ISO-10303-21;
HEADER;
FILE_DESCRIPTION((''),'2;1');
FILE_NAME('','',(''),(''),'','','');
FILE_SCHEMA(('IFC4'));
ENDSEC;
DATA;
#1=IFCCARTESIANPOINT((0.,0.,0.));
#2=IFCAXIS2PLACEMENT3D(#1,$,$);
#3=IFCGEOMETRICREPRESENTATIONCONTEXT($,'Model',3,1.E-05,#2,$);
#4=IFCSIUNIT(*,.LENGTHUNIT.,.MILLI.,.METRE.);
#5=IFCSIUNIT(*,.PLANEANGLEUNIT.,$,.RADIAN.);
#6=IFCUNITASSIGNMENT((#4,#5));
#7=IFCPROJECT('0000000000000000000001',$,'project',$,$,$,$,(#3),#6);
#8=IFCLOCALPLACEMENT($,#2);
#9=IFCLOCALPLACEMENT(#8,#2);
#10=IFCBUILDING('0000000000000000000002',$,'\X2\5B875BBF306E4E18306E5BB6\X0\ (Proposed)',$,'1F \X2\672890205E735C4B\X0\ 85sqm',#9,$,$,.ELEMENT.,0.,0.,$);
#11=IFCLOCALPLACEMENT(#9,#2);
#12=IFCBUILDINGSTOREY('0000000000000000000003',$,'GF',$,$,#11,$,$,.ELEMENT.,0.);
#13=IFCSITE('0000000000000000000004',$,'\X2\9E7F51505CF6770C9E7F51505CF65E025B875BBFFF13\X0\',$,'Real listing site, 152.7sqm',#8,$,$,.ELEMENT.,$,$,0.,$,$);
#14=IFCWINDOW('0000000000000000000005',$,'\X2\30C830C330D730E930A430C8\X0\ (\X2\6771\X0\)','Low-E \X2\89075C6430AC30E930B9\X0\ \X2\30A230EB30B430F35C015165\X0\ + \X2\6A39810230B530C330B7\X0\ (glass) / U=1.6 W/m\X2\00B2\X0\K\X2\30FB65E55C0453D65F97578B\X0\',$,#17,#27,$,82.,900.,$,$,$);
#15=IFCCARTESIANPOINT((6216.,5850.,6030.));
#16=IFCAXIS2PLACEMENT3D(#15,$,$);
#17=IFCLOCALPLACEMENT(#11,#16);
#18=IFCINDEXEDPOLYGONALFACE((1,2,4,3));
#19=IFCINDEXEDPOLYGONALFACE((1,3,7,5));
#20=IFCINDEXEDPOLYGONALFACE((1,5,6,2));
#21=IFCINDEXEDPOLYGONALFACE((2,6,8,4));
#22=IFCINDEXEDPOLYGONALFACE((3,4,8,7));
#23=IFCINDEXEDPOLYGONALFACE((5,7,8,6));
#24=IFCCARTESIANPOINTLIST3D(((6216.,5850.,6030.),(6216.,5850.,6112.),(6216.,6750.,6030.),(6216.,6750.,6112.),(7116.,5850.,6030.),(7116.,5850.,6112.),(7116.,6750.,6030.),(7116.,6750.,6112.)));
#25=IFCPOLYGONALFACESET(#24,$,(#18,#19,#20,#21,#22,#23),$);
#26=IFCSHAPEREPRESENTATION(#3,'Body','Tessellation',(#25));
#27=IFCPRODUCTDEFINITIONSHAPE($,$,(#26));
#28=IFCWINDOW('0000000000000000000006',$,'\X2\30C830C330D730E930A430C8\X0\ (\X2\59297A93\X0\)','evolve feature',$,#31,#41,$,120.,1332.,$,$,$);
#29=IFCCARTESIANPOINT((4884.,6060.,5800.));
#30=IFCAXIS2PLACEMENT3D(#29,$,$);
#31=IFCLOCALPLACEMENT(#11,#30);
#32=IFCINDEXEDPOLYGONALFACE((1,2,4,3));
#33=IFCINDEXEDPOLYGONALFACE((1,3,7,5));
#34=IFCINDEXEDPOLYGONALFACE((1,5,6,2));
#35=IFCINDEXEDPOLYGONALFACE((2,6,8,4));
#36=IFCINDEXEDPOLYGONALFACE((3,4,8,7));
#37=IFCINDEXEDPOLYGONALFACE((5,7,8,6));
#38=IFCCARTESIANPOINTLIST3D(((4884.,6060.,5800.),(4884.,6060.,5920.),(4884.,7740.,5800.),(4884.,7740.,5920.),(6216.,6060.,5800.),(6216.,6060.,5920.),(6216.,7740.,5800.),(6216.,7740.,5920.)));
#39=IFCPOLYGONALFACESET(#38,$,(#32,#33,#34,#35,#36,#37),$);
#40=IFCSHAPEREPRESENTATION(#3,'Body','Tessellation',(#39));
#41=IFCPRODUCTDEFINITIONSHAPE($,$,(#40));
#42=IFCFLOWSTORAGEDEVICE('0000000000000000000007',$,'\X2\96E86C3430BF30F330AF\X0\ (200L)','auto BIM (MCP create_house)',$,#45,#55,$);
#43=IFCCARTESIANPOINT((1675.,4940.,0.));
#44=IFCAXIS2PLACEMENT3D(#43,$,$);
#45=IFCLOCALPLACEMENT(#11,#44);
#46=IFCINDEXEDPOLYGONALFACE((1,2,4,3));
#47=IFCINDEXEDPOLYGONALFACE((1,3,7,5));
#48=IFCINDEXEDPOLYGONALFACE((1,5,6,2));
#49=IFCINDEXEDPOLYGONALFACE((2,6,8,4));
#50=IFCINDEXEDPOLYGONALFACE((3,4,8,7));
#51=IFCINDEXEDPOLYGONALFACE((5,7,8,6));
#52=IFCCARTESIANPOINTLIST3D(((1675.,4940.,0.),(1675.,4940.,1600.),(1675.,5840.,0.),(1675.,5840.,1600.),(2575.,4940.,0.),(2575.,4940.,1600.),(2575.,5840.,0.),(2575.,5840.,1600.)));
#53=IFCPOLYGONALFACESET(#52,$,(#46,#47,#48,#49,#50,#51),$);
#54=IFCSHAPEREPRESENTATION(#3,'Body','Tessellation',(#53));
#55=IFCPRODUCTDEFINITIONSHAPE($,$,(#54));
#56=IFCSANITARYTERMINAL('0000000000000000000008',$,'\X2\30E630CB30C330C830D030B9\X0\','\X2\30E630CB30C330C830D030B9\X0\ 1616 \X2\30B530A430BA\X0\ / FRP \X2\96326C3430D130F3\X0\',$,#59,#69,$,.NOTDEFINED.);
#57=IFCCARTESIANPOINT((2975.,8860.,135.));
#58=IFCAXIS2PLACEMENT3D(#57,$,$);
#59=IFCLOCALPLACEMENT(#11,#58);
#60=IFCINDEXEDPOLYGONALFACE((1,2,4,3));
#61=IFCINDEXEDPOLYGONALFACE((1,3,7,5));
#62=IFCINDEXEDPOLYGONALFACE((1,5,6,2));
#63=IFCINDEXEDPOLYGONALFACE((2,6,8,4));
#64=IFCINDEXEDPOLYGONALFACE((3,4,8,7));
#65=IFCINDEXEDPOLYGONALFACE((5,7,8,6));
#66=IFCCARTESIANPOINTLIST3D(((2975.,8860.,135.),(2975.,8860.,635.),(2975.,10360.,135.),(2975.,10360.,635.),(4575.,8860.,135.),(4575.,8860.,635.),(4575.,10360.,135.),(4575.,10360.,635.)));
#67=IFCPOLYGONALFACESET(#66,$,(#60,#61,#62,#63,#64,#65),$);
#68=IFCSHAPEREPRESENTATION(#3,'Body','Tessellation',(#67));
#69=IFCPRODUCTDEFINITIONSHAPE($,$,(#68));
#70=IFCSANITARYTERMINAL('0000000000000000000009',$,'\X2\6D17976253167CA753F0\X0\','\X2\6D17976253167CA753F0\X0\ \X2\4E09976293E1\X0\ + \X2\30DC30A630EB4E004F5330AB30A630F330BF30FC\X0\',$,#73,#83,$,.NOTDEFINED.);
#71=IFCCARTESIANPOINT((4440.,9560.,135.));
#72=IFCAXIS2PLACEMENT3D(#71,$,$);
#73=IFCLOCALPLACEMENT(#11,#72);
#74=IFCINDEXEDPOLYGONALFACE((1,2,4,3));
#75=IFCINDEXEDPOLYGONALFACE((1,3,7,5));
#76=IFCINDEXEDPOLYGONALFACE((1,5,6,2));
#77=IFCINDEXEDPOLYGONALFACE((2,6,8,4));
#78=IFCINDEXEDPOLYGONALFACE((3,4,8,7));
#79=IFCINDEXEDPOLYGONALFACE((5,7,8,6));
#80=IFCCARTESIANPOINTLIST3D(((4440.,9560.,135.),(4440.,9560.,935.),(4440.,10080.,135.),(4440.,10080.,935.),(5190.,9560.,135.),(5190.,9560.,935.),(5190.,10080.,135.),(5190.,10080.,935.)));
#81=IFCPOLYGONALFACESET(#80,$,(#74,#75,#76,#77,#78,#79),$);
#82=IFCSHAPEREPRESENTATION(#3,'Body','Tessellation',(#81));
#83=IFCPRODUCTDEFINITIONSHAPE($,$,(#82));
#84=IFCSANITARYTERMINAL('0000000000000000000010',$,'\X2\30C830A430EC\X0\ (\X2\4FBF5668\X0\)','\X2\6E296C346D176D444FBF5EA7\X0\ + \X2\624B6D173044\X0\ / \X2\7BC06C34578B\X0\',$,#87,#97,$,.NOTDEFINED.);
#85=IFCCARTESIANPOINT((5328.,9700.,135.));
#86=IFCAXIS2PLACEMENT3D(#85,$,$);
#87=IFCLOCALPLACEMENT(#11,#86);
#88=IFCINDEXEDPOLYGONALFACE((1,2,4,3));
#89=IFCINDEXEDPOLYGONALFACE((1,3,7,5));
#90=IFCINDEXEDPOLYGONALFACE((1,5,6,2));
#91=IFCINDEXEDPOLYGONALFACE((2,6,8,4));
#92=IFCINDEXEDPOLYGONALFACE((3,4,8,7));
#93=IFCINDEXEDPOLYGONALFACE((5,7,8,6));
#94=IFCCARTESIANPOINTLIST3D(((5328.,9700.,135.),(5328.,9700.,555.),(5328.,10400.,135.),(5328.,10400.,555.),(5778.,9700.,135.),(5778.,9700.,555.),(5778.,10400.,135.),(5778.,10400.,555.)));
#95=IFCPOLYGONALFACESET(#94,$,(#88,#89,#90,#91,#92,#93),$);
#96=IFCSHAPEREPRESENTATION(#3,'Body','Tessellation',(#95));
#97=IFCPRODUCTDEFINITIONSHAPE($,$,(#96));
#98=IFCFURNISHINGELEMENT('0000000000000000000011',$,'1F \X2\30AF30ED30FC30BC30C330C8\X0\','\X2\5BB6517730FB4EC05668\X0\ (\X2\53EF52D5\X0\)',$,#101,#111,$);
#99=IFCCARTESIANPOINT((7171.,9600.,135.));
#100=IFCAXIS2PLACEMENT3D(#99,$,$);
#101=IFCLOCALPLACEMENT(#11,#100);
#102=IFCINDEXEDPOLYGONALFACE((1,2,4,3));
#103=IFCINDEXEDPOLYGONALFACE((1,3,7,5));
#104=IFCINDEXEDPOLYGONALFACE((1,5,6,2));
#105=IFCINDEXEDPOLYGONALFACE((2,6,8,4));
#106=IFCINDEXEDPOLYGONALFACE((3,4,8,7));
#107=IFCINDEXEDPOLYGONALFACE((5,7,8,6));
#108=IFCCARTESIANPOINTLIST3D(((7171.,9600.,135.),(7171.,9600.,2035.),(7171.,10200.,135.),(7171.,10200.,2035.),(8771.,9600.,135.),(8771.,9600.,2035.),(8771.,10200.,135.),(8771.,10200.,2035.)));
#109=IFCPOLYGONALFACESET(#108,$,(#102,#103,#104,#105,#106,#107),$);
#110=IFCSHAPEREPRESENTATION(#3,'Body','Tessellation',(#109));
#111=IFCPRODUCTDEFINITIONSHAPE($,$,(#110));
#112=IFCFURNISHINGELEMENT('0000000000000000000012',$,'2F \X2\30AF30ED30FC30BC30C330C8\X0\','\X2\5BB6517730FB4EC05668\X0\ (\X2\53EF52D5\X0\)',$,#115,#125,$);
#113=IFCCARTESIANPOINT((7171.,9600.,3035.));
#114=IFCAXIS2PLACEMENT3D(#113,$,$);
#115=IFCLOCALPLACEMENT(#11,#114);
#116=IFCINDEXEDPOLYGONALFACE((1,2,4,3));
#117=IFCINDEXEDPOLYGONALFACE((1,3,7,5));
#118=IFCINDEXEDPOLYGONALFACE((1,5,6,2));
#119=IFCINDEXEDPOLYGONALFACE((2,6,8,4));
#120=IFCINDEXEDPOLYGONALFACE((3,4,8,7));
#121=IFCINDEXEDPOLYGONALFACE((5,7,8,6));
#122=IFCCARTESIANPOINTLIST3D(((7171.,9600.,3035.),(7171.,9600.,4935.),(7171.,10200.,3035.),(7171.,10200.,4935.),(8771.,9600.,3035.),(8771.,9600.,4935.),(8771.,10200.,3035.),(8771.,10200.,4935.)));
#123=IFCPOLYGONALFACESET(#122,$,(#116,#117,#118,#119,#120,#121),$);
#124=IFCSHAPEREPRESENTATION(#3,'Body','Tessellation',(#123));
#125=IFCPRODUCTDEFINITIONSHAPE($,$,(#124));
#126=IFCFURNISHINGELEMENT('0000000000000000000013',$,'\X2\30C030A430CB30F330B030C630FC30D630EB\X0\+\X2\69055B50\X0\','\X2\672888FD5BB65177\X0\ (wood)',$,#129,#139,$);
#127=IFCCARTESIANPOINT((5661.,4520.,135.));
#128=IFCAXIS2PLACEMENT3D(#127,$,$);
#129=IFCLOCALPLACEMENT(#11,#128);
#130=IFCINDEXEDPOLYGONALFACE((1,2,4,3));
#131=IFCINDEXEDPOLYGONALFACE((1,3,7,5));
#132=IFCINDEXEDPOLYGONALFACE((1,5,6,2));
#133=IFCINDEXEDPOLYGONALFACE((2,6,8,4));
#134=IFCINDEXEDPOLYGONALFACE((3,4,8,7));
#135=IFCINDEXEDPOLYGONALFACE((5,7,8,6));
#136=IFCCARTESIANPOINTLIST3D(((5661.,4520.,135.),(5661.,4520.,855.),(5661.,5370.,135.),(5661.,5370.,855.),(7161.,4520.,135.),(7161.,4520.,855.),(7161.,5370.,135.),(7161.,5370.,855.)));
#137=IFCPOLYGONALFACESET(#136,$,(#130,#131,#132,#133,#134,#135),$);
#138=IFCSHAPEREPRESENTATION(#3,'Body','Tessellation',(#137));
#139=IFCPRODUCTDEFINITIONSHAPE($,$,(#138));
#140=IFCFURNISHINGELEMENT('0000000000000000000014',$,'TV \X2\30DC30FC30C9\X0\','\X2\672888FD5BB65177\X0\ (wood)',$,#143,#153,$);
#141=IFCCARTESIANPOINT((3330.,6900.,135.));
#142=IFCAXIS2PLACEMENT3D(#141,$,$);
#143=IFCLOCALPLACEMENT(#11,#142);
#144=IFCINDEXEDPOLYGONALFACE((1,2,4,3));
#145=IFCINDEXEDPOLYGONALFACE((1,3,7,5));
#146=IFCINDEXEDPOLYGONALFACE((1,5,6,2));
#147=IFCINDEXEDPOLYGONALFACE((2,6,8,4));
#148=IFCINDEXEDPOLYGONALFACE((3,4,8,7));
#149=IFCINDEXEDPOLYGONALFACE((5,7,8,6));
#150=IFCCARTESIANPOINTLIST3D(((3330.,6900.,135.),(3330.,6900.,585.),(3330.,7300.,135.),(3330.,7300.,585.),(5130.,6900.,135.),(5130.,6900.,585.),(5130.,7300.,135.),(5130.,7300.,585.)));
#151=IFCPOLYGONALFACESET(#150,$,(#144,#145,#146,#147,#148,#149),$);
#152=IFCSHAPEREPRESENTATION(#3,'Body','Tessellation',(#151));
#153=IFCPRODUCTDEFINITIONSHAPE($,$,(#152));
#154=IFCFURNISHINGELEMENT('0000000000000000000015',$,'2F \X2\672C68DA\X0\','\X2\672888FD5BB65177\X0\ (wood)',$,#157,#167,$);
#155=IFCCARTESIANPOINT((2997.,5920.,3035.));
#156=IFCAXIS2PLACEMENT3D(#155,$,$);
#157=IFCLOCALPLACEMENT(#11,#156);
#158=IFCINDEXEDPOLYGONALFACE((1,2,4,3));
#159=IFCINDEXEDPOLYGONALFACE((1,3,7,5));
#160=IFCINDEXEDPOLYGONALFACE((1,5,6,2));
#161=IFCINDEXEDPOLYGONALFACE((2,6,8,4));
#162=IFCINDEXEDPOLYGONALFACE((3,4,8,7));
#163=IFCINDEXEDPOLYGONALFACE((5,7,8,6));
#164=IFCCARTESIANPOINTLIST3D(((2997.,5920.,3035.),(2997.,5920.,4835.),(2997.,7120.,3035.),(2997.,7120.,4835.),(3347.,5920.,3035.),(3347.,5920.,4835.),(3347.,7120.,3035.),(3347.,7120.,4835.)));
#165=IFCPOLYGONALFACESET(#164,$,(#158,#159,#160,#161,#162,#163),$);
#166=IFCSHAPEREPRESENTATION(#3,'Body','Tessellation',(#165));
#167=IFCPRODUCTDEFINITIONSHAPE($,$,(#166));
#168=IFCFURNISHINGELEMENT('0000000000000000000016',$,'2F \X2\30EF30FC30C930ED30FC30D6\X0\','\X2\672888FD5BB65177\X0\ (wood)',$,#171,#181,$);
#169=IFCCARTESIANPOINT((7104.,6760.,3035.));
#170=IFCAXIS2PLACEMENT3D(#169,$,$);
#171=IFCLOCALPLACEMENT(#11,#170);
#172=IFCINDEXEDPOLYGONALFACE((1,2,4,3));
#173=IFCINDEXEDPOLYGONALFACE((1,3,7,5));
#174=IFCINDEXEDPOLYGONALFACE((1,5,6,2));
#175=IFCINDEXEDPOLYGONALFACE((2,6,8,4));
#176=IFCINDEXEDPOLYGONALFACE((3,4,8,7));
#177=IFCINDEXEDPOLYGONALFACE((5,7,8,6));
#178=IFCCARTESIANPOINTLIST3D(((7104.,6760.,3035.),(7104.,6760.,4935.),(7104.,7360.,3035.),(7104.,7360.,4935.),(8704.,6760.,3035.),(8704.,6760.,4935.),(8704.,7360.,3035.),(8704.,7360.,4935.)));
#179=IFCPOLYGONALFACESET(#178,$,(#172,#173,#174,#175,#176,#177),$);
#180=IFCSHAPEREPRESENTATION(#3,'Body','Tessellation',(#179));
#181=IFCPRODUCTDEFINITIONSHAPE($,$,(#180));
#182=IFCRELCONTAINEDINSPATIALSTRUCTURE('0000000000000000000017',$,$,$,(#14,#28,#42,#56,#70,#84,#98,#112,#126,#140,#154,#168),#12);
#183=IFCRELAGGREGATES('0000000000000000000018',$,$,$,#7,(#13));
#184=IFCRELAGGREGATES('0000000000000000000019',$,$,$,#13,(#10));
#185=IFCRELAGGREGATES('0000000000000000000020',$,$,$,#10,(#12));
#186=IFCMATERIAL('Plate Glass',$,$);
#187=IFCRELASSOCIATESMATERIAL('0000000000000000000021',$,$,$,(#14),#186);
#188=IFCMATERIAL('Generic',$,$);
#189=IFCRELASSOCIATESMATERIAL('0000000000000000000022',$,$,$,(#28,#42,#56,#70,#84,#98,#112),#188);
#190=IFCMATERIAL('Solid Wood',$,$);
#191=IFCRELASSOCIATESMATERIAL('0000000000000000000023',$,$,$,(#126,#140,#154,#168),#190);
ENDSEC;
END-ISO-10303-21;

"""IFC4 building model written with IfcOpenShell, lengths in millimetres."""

from ifc_helpers import new_model, si_unit, frame, frame_2d, origin, place, context, project, spatial, rectangle, extrude, material, element, save


model = new_model("IFC4")

# Units and contexts
model_context = context("Model", 3, precision=1e-05, world=origin())
ifc_project = project(units=[si_unit("LENGTHUNIT", "METRE", prefix="MILLI"), si_unit("PLANEANGLEUNIT", "RADIAN")], contexts=[model_context])

# Site, building, storey
site_placement = place(None, origin())
site = spatial("IfcSite", under=ifc_project, at=site_placement, Name="鹿児島県鹿児島市宇宿３", ObjectType="Real listing site, 152.7sqm", CompositionType="ELEMENT", RefElevation=0.0)
building_placement = place(site_placement, origin())
building = spatial("IfcBuilding", under=site, at=building_placement, Name="宇宿の丘の家 (Proposed)", ObjectType="1F 木造平屋 85sqm", CompositionType="ELEMENT", ElevationOfRefHeight=0.0, ElevationOfTerrain=0.0)
storey_placement = place(building_placement, origin())
storey = spatial("IfcBuildingStorey", under=building, at=storey_placement, Name="GF", CompositionType="ELEMENT", Elevation=0.0)

# Shared definitions
ifc_material_1 = material(Name="Solid Wood")
ifc_material_2 = material(Name="Plate Glass")

# Windows
window_1_placement = place(storey_placement, frame((6216.0, 5850.0, 6030.0)))
element("IfcWindow", 1, at=window_1_placement, inside=storey, material=ifc_material_2, Name="トップライト (東)", Description="Low-E 複層ガラス アルゴン封入 + 樹脂サッシ (glass) / U=1.6 W/m²K・日射取得型", OverallHeight=82.0, OverallWidth=900.0, context=model_context, shape_type="SweptSolid", body=[
    extrude(rectangle(XDim=900.0, YDim=900.0, at=frame_2d((450.0, 450.0))), frame((6216.0, 5850.0, 6030.0)), (0.0, 0.0, 1.0), 82.0),
])
ifc_material_3 = material(Name="Generic")
window_2_placement = place(storey_placement, frame((4884.0, 6060.0, 5800.0)))
element("IfcWindow", 2, at=window_2_placement, inside=storey, material=ifc_material_3, Name="トップライト (天窓)", Description="evolve feature", OverallHeight=120.0, OverallWidth=1332.0, context=model_context, shape_type="SweptSolid", body=[
    extrude(rectangle(XDim=1332.0, YDim=1680.0, at=frame_2d((666.0, 840.0))), frame((4884.0, 6060.0, 5800.0)), (0.0, 0.0, 1.0), 120.0),
])

# Flow storage device
flow_storage_device_placement = place(storey_placement, frame((1675.0, 4940.0, 0.0)))
element("IfcFlowStorageDevice", 3, at=flow_storage_device_placement, inside=storey, material=ifc_material_3, Name="雨水タンク (200L)", Description="auto BIM (MCP create_house)", context=model_context, shape_type="SweptSolid", body=[
    extrude(rectangle(XDim=900.0, YDim=900.0, at=frame_2d((450.0, 450.0))), frame((1675.0, 4940.0, 0.0)), (0.0, 0.0, 1.0), 1600.0),
])

# Sanitary terminals
sanitary_terminal_1_placement = place(storey_placement, frame((2975.0, 8860.0, 135.0)))
element("IfcSanitaryTerminal", 4, at=sanitary_terminal_1_placement, inside=storey, material=ifc_material_3, Name="ユニットバス", Description="ユニットバス 1616 サイズ / FRP 防水パン", PredefinedType="NOTDEFINED", context=model_context, shape_type="SweptSolid", body=[
    extrude(rectangle(XDim=1600.0, YDim=1500.0, at=frame_2d((800.0, 750.0))), frame((2975.0, 8860.0, 135.0)), (0.0, 0.0, 1.0), 500.0),
])
sanitary_terminal_2_placement = place(storey_placement, frame((4440.0, 9560.0, 135.0)))
element("IfcSanitaryTerminal", 5, at=sanitary_terminal_2_placement, inside=storey, material=ifc_material_3, Name="洗面化粧台", Description="洗面化粧台 三面鏡 + ボウル一体カウンター", PredefinedType="NOTDEFINED", context=model_context, shape_type="SweptSolid", body=[
    extrude(rectangle(XDim=750.0, YDim=520.0, at=frame_2d((375.0, 260.0))), frame((4440.0, 9560.0, 135.0)), (0.0, 0.0, 1.0), 800.0),
])
sanitary_terminal_3_placement = place(storey_placement, frame((5328.0, 9700.0, 135.0)))
element("IfcSanitaryTerminal", 6, at=sanitary_terminal_3_placement, inside=storey, material=ifc_material_3, Name="トイレ (便器)", Description="温水洗浄便座 + 手洗い / 節水型", PredefinedType="NOTDEFINED", context=model_context, shape_type="SweptSolid", body=[
    extrude(rectangle(XDim=450.0, YDim=700.0, at=frame_2d((225.0, 350.0))), frame((5328.0, 9700.0, 135.0)), (0.0, 0.0, 1.0), 420.0),
])

# Furnishing elements
furnishing_1_placement = place(storey_placement, frame((7171.0, 9600.0, 135.0)))
element("IfcFurnishingElement", 7, at=furnishing_1_placement, inside=storey, material=ifc_material_3, Name="1F クローゼット", Description="家具・什器 (可動)", context=model_context, shape_type="SweptSolid", body=[
    extrude(rectangle(XDim=1600.0, YDim=600.0, at=frame_2d((800.0, 300.0))), frame((7171.0, 9600.0, 135.0)), (0.0, 0.0, 1.0), 1900.0),
])
furnishing_2_placement = place(storey_placement, frame((7171.0, 9600.0, 3035.0)))
element("IfcFurnishingElement", 8, at=furnishing_2_placement, inside=storey, material=ifc_material_3, Name="2F クローゼット", Description="家具・什器 (可動)", context=model_context, shape_type="SweptSolid", body=[
    extrude(rectangle(XDim=1600.0, YDim=600.0, at=frame_2d((800.0, 300.0))), frame((7171.0, 9600.0, 3035.0)), (0.0, 0.0, 1.0), 1900.0),
])
furnishing_3_placement = place(storey_placement, frame((5661.0, 4520.0, 135.0)))
element("IfcFurnishingElement", 9, at=furnishing_3_placement, inside=storey, material=ifc_material_1, Name="ダイニングテーブル+椅子", Description="木製家具 (wood)", context=model_context, shape_type="SweptSolid", body=[
    extrude(rectangle(XDim=1500.0, YDim=850.0, at=frame_2d((750.0, 425.0))), frame((5661.0, 4520.0, 135.0)), (0.0, 0.0, 1.0), 720.0),
])
furnishing_4_placement = place(storey_placement, frame((3330.0, 6900.0, 135.0)))
element("IfcFurnishingElement", 10, at=furnishing_4_placement, inside=storey, material=ifc_material_1, Name="TV ボード", Description="木製家具 (wood)", context=model_context, shape_type="SweptSolid", body=[
    extrude(rectangle(XDim=1800.0, YDim=400.0, at=frame_2d((900.0, 200.0))), frame((3330.0, 6900.0, 135.0)), (0.0, 0.0, 1.0), 450.0),
])
furnishing_5_placement = place(storey_placement, frame((2997.0, 5920.0, 3035.0)))
element("IfcFurnishingElement", 11, at=furnishing_5_placement, inside=storey, material=ifc_material_1, Name="2F 本棚", Description="木製家具 (wood)", context=model_context, shape_type="SweptSolid", body=[
    extrude(rectangle(XDim=350.0, YDim=1200.0, at=frame_2d((175.0, 600.0))), frame((2997.0, 5920.0, 3035.0)), (0.0, 0.0, 1.0), 1800.0),
])
furnishing_6_placement = place(storey_placement, frame((7104.0, 6760.0, 3035.0)))
element("IfcFurnishingElement", 12, at=furnishing_6_placement, inside=storey, material=ifc_material_1, Name="2F ワードローブ", Description="木製家具 (wood)", context=model_context, shape_type="SweptSolid", body=[
    extrude(rectangle(XDim=1600.0, YDim=600.0, at=frame_2d((800.0, 300.0))), frame((7104.0, 6760.0, 3035.0)), (0.0, 0.0, 1.0), 1900.0),
])

save(model, "model.ifc")
